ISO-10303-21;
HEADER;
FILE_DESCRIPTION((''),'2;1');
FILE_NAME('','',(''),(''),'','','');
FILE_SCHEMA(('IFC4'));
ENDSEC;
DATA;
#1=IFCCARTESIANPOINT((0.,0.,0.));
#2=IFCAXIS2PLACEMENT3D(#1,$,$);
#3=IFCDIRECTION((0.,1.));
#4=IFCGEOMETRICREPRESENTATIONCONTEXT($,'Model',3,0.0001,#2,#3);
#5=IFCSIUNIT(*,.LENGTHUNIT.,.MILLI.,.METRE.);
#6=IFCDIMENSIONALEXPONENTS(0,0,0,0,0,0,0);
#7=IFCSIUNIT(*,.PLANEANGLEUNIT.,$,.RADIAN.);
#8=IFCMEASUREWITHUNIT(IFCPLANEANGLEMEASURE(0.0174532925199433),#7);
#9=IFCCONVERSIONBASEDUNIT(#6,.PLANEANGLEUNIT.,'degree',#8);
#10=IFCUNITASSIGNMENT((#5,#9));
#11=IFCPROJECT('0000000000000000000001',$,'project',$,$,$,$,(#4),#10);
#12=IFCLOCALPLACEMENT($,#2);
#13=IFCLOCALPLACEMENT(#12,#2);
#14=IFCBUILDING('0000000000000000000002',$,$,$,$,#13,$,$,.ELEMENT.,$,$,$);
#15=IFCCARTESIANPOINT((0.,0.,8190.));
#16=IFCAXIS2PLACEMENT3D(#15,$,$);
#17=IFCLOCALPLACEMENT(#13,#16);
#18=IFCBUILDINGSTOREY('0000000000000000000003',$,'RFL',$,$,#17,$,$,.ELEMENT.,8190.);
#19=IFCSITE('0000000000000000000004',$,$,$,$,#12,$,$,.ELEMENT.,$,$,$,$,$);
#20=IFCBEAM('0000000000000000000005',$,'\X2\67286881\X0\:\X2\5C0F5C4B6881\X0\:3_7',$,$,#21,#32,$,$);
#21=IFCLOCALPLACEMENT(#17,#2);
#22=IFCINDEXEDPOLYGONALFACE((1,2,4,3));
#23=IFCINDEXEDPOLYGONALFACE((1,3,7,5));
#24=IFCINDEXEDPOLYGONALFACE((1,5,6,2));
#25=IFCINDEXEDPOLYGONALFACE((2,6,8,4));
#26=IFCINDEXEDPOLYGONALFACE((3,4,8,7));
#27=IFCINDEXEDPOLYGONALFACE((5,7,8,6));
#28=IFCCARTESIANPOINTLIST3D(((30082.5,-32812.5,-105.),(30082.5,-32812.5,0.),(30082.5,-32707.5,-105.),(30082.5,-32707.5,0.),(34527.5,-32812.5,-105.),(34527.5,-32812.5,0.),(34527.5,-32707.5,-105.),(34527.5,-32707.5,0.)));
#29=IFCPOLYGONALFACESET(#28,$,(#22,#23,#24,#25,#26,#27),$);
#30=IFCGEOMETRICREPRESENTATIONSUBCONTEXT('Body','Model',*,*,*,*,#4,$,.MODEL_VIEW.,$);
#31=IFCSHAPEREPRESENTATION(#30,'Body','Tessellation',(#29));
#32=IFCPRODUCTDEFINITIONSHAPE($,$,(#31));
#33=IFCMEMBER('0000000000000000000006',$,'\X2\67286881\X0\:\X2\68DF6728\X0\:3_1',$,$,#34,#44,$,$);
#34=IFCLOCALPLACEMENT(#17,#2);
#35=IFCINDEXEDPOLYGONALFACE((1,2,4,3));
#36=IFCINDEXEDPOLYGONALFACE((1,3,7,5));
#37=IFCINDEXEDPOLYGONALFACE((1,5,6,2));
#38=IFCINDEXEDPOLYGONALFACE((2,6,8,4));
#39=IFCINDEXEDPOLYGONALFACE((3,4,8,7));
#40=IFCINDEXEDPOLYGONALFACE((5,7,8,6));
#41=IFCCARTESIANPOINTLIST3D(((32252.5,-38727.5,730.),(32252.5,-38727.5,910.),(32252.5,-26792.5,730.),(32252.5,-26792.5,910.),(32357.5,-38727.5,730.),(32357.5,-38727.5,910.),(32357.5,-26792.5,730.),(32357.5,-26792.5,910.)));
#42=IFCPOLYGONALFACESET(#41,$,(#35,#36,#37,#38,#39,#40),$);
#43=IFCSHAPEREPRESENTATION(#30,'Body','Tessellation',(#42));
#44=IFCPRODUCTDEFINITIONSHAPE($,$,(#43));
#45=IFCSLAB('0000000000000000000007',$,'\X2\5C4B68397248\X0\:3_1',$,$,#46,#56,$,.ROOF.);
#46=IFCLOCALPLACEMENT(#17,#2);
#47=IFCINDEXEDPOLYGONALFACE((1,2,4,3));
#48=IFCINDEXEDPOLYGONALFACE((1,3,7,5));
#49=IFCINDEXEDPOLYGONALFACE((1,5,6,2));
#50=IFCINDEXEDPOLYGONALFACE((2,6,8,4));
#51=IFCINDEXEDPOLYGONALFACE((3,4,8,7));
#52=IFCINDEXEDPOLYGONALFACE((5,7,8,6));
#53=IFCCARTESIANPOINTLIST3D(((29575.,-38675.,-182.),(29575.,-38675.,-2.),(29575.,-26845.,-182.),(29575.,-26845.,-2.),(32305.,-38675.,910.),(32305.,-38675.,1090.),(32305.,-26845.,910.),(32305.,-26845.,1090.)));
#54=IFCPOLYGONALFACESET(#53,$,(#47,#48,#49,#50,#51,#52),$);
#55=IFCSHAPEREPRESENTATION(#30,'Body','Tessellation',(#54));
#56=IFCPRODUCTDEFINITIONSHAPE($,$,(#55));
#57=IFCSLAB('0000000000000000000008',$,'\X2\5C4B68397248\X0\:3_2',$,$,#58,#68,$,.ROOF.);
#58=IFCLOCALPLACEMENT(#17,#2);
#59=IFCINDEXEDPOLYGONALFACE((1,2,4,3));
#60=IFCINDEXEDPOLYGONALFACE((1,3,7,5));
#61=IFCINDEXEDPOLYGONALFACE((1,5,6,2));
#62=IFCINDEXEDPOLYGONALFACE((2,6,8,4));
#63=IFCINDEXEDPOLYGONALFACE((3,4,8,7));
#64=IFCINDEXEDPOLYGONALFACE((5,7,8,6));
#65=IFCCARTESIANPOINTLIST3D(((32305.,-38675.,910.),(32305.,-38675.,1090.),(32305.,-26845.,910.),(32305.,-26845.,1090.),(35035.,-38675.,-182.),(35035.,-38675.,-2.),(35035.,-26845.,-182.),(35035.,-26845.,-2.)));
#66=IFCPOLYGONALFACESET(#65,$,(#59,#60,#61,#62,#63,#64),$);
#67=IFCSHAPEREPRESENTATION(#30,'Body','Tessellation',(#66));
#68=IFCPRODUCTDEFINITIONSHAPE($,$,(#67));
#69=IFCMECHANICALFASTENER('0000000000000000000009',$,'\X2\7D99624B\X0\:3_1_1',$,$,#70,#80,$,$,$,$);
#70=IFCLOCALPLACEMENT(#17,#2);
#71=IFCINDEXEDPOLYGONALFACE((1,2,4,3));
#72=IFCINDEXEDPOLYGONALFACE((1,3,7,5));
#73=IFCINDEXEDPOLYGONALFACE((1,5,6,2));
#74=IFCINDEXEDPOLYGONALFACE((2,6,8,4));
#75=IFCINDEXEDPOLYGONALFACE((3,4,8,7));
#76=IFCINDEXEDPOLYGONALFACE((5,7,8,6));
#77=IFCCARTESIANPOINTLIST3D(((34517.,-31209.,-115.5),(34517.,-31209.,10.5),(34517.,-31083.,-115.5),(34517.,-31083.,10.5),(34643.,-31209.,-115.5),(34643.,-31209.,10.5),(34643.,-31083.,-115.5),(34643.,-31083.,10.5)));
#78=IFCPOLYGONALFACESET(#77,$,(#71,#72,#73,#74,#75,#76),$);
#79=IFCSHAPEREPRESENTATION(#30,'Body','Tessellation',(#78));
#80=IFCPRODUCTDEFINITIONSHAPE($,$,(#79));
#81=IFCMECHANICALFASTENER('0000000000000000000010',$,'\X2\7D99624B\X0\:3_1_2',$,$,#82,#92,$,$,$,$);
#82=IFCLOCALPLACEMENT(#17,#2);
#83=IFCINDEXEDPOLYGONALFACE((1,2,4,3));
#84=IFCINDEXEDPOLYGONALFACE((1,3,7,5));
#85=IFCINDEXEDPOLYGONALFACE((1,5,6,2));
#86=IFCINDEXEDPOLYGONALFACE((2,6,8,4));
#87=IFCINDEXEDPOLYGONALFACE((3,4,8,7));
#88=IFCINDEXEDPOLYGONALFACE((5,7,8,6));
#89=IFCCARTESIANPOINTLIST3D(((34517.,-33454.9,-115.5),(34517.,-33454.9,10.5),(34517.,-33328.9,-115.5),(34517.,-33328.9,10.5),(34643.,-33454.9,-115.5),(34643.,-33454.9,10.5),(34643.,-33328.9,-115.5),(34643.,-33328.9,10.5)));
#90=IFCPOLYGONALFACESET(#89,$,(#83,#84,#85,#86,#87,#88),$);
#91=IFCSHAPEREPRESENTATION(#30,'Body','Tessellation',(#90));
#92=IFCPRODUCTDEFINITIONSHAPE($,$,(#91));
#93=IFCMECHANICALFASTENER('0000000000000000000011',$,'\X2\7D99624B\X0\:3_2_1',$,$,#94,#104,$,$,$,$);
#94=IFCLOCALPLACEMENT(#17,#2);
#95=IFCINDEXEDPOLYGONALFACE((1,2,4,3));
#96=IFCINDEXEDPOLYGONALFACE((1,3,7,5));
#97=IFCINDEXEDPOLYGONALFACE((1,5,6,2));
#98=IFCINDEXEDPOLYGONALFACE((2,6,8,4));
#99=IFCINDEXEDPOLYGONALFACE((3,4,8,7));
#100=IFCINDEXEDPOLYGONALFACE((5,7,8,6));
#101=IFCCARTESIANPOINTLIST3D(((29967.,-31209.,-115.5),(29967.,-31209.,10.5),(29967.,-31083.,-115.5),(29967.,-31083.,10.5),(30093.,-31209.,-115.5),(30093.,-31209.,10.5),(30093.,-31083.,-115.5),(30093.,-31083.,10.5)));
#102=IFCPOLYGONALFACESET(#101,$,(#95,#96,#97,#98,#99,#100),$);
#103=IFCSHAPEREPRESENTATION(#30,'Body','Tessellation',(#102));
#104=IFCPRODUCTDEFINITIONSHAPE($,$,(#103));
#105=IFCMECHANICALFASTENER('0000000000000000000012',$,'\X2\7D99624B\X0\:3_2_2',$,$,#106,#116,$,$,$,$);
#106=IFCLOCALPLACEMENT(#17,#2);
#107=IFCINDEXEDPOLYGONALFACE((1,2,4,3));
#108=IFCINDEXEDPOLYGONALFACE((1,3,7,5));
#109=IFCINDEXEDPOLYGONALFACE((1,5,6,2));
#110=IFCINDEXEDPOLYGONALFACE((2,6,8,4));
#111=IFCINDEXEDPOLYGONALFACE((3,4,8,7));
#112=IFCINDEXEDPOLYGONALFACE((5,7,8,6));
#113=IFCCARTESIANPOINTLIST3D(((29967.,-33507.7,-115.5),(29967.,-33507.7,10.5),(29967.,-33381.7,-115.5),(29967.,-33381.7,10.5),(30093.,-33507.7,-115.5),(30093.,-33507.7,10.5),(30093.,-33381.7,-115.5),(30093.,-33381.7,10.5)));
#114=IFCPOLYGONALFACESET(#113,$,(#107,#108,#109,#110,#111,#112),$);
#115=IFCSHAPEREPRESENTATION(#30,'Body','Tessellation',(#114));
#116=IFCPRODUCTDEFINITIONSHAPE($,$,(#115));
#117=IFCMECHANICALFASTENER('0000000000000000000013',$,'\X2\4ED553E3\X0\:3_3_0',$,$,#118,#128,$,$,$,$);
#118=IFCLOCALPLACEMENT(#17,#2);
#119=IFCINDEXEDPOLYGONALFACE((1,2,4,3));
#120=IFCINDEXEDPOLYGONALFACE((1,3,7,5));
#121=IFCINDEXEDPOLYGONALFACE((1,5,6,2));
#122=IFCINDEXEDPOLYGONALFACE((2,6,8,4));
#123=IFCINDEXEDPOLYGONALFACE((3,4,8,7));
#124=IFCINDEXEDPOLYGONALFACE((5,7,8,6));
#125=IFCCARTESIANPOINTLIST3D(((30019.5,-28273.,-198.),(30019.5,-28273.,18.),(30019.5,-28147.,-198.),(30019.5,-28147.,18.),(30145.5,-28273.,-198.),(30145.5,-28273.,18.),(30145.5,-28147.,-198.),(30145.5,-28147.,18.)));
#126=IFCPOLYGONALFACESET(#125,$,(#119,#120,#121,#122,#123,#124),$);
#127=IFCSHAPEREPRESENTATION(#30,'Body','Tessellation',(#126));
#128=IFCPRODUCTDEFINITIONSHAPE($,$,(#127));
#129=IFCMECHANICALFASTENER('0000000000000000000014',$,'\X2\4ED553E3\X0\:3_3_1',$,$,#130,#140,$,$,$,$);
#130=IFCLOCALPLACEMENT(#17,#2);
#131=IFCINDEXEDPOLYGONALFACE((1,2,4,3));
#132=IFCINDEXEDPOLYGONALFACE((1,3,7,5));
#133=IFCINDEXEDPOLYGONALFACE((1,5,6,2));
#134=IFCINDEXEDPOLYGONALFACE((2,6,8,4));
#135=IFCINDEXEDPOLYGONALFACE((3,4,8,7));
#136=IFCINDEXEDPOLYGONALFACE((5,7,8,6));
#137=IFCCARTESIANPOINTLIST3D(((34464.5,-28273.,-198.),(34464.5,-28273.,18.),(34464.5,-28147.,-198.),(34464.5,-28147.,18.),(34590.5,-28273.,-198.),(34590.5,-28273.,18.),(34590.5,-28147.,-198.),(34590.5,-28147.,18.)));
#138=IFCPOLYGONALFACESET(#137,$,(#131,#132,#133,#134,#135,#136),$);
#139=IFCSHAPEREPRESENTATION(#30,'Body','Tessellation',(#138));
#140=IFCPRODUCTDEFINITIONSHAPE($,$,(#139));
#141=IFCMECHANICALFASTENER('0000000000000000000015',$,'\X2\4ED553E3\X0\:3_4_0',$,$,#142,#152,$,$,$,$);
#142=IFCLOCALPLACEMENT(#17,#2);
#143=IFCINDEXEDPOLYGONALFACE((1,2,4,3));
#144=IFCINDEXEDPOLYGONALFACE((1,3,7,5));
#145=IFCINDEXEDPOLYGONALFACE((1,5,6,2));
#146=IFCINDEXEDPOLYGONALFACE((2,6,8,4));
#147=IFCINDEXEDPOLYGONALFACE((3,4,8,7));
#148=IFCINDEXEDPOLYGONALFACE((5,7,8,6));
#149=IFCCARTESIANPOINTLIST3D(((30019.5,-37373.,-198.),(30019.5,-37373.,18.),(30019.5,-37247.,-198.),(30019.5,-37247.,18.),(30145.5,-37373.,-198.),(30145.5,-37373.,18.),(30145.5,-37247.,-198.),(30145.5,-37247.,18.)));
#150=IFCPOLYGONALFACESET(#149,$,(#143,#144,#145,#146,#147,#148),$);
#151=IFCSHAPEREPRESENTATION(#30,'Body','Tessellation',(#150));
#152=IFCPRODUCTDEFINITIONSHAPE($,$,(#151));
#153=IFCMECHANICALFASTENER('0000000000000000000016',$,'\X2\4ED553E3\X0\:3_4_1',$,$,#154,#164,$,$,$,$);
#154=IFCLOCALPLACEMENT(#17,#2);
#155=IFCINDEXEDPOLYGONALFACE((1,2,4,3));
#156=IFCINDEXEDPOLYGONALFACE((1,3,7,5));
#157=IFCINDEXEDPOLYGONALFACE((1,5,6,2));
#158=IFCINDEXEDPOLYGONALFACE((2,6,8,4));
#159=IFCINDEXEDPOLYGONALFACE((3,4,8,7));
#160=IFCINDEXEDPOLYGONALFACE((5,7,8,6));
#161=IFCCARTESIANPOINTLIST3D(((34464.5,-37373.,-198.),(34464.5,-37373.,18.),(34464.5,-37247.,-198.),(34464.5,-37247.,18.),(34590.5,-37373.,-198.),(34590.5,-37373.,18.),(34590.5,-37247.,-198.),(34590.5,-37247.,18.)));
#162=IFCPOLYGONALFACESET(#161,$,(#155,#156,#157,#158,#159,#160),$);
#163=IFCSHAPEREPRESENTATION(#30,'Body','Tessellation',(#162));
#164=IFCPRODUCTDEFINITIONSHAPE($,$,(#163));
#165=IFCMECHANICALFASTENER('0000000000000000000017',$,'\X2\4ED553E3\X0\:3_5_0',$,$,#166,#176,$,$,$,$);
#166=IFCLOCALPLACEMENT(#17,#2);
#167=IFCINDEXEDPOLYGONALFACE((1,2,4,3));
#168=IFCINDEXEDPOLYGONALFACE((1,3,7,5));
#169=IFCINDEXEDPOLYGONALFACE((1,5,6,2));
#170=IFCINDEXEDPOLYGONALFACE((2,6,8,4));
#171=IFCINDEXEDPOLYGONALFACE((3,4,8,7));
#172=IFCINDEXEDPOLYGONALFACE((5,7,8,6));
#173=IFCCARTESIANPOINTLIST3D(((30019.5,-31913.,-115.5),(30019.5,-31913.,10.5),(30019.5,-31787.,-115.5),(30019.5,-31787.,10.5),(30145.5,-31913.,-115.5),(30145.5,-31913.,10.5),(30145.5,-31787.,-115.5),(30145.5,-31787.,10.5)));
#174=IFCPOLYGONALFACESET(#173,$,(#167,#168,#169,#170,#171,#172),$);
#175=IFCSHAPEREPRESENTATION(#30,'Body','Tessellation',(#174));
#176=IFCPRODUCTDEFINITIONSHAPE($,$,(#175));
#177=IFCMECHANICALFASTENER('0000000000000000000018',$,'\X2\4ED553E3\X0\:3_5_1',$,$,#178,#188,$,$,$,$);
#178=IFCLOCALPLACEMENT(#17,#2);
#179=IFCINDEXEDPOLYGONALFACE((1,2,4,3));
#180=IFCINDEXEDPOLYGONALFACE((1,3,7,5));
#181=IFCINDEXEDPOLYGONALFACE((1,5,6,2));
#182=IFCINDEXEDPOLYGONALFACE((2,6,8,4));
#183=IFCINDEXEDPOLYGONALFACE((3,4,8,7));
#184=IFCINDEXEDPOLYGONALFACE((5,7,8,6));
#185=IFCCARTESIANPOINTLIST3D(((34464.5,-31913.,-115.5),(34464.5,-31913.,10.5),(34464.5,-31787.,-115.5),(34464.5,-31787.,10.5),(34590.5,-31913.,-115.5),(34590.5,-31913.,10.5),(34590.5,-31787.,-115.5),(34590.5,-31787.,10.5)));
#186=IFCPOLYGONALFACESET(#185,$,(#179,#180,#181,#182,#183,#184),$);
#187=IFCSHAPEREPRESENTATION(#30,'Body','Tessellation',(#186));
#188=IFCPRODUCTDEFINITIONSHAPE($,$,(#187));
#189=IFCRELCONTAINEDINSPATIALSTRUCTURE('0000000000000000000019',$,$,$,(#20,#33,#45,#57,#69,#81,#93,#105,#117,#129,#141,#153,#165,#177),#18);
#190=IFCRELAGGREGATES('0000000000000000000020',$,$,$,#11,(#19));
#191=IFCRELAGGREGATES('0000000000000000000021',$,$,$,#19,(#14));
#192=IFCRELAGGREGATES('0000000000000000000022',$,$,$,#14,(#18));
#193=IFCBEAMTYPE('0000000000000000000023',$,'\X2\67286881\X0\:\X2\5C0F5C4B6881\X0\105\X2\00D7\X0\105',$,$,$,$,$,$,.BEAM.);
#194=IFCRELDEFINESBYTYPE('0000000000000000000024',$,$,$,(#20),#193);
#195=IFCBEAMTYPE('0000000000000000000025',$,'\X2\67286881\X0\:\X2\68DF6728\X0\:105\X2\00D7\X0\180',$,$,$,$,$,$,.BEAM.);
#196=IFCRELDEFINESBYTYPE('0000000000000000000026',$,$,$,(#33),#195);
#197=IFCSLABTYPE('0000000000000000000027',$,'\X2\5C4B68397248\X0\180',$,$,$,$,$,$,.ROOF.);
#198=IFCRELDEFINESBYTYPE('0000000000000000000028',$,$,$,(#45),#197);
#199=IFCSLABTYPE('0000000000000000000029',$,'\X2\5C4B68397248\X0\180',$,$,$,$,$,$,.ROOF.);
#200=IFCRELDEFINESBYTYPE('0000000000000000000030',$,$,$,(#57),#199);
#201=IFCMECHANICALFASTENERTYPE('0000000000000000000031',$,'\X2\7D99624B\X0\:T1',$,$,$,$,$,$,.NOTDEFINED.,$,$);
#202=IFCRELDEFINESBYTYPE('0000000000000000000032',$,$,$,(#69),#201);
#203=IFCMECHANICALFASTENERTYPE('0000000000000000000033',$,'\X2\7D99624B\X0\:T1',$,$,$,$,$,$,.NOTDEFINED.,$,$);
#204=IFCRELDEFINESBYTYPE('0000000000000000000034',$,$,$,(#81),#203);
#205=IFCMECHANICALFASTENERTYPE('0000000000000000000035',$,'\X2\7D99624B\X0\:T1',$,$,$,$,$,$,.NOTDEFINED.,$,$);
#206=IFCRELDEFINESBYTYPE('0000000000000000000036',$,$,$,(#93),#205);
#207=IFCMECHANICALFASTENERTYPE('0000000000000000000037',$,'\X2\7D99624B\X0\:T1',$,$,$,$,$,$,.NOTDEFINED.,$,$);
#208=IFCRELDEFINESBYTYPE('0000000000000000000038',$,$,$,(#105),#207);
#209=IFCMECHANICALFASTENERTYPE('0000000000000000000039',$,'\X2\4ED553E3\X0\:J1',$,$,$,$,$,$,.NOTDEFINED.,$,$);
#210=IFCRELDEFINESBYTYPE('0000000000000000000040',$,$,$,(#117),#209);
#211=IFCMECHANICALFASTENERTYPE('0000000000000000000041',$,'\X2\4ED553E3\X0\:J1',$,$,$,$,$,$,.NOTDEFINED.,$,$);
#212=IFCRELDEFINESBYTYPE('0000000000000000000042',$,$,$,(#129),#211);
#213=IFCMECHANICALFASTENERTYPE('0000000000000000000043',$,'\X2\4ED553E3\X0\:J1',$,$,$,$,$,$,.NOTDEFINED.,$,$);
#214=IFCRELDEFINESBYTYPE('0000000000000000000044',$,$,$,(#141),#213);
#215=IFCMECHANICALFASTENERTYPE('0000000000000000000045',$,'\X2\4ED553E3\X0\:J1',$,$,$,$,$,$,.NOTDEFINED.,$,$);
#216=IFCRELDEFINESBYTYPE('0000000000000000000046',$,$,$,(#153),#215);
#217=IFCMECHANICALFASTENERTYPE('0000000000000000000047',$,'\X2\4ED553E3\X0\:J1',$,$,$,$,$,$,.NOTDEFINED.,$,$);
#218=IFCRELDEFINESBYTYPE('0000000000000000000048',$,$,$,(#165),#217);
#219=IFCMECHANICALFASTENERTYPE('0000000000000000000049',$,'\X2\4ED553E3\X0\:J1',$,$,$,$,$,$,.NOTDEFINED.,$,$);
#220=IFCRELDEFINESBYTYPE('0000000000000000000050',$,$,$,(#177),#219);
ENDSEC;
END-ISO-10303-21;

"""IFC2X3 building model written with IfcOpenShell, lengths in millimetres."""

from ifc_helpers import new_model, entity, si_unit, converted_unit, direction, frame, origin, origin_with_axes, origin_2d, place, context, subcontext, project, spatial, polyline, rectangle, outline, extrude, type_object, element, save


model = new_model("IFC2X3")

# Units and contexts
model_context = context("Model", 3, precision=0.0001, world=origin(), true_north=direction((0.0, 1.0)))
body_context = subcontext(model_context, "Body", "Model", "MODEL_VIEW")
ifc_project = project(units=[si_unit("LENGTHUNIT", "METRE", prefix="MILLI"), converted_unit("PLANEANGLEUNIT", "degree", entity("IfcPlaneAngleMeasure", 0.0174532925199433), si_unit("PLANEANGLEUNIT", "RADIAN"), dimensions=[0, 0, 0, 0, 0, 0, 0])], contexts=[model_context])

# Site, building, storey
site_placement = place(None, origin())
site = spatial("IfcSite", under=ifc_project, at=site_placement, CompositionType="ELEMENT")
building_placement = place(site_placement, origin())
building = spatial("IfcBuilding", under=site, at=building_placement, CompositionType="ELEMENT")
storey_placement = place(building_placement, frame((0.0, 0.0, 8190.0)))
storey = spatial("IfcBuildingStorey", under=building, at=storey_placement, Name="RFL", CompositionType="ELEMENT", Elevation=8190.0)

# Beam
beam_type_1 = type_object("IfcBeamType", Name="木梁:小屋梁105×105", PredefinedType="BEAM")
beam_1_placement = place(storey_placement, frame((30082.5, -32760.0, -52.5), z_axis=(1.0, 0.0, 0.0), x_axis=(0.0, 1.0, 0.0)))
element("IfcBeam", 1, at=beam_1_placement, inside=storey, type_object=beam_type_1, Name="木梁:小屋梁:3_7", context=body_context, shape_type="SweptSolid", body=[
    extrude(rectangle(XDim=105.0, YDim=105.0, at=origin_2d()), origin_with_axes(), (0.0, 0.0, 1.0), 4445.0),
])

# Member
beam_type_2 = type_object("IfcBeamType", Name="木梁:棟木:105×180", PredefinedType="BEAM")
member_placement = place(storey_placement, frame((32305.0, -26792.5, 820.0), z_axis=(0.0, -1.0, 0.0), x_axis=(-1.0, 0.0, 0.0)))
element("IfcMember", 2, at=member_placement, inside=storey, type_object=beam_type_2, Name="木梁:棟木:3_1", context=body_context, shape_type="SweptSolid", body=[
    extrude(rectangle(XDim=105.0, YDim=180.0, at=origin_2d()), origin_with_axes(), (0.0, 0.0, 1.0), 11935.0),
])

# Slabs
slab_type_1 = type_object("IfcSlabType", Name="屋根版180", PredefinedType="ROOF")
slab_1_placement = place(storey_placement, frame((29575.0, -26845.0, -182.0), z_axis=(0.371391, 0.0, -0.928477), x_axis=(0.928477, 0.0, 0.371391)))
element("IfcSlab", 3, at=slab_1_placement, inside=storey, type_object=slab_type_1, Name="屋根版:3_1", PredefinedType="ROOF", context=body_context, shape_type="SweptSolid", body=[
    extrude(outline(polyline([(0.0, 0.0, 0.0), (2940.3, 0.0, 0.0), (2940.3, 11830.0, 0.0), (0.0, 11830.0, 0.0), (0.0, 0.0, 0.0)])), origin_with_axes(), (0.371391, 0.0, -0.928477), 180.0),
])
slab_type_2 = type_object("IfcSlabType", Name="屋根版180", PredefinedType="ROOF")
slab_2_placement = place(storey_placement, frame((35035.0, -26845.0, -182.0), z_axis=(0.371391, 0.0, 0.928477), x_axis=(-0.928477, 0.0, 0.371391)))
element("IfcSlab", 4, at=slab_2_placement, inside=storey, type_object=slab_type_2, Name="屋根版:3_2", PredefinedType="ROOF", context=body_context, shape_type="SweptSolid", body=[
    extrude(outline(polyline([(0.0, 0.0, 0.0), (2940.3, 0.0, 0.0), (2940.3, 11830.0, 0.0), (0.0, 11830.0, 0.0), (0.0, 0.0, 0.0)])), origin_with_axes(), (0.371391, 0.0, 0.928477), 180.0),
])

# Mechanical fasteners
mechanical_fastener_type_1 = type_object("IfcMechanicalFastenerType", Name="継手:T1")
mechanical_fastener_1_placement = place(storey_placement, frame((34580.0, -31146.0, -115.5)))
element("IfcMechanicalFastener", 5, at=mechanical_fastener_1_placement, inside=storey, type_object=mechanical_fastener_type_1, Name="継手:3_1_1", context=body_context, shape_type="SweptSolid", body=[
    extrude(rectangle(XDim=126.0, YDim=126.0, at=origin_2d()), origin_with_axes(), (0.0, 0.0, 1.0), 126.0),
])
mechanical_fastener_type_2 = type_object("IfcMechanicalFastenerType", Name="継手:T1")
mechanical_fastener_2_placement = place(storey_placement, frame((34580.0, -33391.9, -115.5)))
element("IfcMechanicalFastener", 6, at=mechanical_fastener_2_placement, inside=storey, type_object=mechanical_fastener_type_2, Name="継手:3_1_2", context=body_context, shape_type="SweptSolid", body=[
    extrude(rectangle(XDim=126.0, YDim=126.0, at=origin_2d()), origin_with_axes(), (0.0, 0.0, 1.0), 126.0),
])
mechanical_fastener_type_3 = type_object("IfcMechanicalFastenerType", Name="継手:T1")
mechanical_fastener_3_placement = place(storey_placement, frame((30030.0, -31146.0, -115.5)))
element("IfcMechanicalFastener", 7, at=mechanical_fastener_3_placement, inside=storey, type_object=mechanical_fastener_type_3, Name="継手:3_2_1", context=body_context, shape_type="SweptSolid", body=[
    extrude(rectangle(XDim=126.0, YDim=126.0, at=origin_2d()), origin_with_axes(), (0.0, 0.0, 1.0), 126.0),
])
mechanical_fastener_type_4 = type_object("IfcMechanicalFastenerType", Name="継手:T1")
mechanical_fastener_4_placement = place(storey_placement, frame((30030.0, -33444.7, -115.5)))
element("IfcMechanicalFastener", 8, at=mechanical_fastener_4_placement, inside=storey, type_object=mechanical_fastener_type_4, Name="継手:3_2_2", context=body_context, shape_type="SweptSolid", body=[
    extrude(rectangle(XDim=126.0, YDim=126.0, at=origin_2d()), origin_with_axes(), (0.0, 0.0, 1.0), 126.0),
])
mechanical_fastener_type_5 = type_object("IfcMechanicalFastenerType", Name="仕口:J1")
mechanical_fastener_5_placement = place(storey_placement, frame((30082.5, -28210.0, -198.0)))
element("IfcMechanicalFastener", 9, at=mechanical_fastener_5_placement, inside=storey, type_object=mechanical_fastener_type_5, Name="仕口:3_3_0", context=body_context, shape_type="SweptSolid", body=[
    extrude(rectangle(XDim=126.0, YDim=126.0, at=origin_2d()), origin_with_axes(), (0.0, 0.0, 1.0), 216.0),
])
mechanical_fastener_type_6 = type_object("IfcMechanicalFastenerType", Name="仕口:J1")
mechanical_fastener_6_placement = place(storey_placement, frame((34527.5, -28210.0, -198.0)))
element("IfcMechanicalFastener", 10, at=mechanical_fastener_6_placement, inside=storey, type_object=mechanical_fastener_type_6, Name="仕口:3_3_1", context=body_context, shape_type="SweptSolid", body=[
    extrude(rectangle(XDim=126.0, YDim=126.0, at=origin_2d()), origin_with_axes(), (0.0, 0.0, 1.0), 216.0),
])
mechanical_fastener_type_7 = type_object("IfcMechanicalFastenerType", Name="仕口:J1")
mechanical_fastener_7_placement = place(storey_placement, frame((30082.5, -37310.0, -198.0)))
element("IfcMechanicalFastener", 11, at=mechanical_fastener_7_placement, inside=storey, type_object=mechanical_fastener_type_7, Name="仕口:3_4_0", context=body_context, shape_type="SweptSolid", body=[
    extrude(rectangle(XDim=126.0, YDim=126.0, at=origin_2d()), origin_with_axes(), (0.0, 0.0, 1.0), 216.0),
])
mechanical_fastener_type_8 = type_object("IfcMechanicalFastenerType", Name="仕口:J1")
mechanical_fastener_8_placement = place(storey_placement, frame((34527.5, -37310.0, -198.0)))
element("IfcMechanicalFastener", 12, at=mechanical_fastener_8_placement, inside=storey, type_object=mechanical_fastener_type_8, Name="仕口:3_4_1", context=body_context, shape_type="SweptSolid", body=[
    extrude(rectangle(XDim=126.0, YDim=126.0, at=origin_2d()), origin_with_axes(), (0.0, 0.0, 1.0), 216.0),
])
mechanical_fastener_type_9 = type_object("IfcMechanicalFastenerType", Name="仕口:J1")
mechanical_fastener_9_placement = place(storey_placement, frame((30082.5, -31850.0, -115.5)))
element("IfcMechanicalFastener", 13, at=mechanical_fastener_9_placement, inside=storey, type_object=mechanical_fastener_type_9, Name="仕口:3_5_0", context=body_context, shape_type="SweptSolid", body=[
    extrude(rectangle(XDim=126.0, YDim=126.0, at=origin_2d()), origin_with_axes(), (0.0, 0.0, 1.0), 126.0),
])
mechanical_fastener_type_10 = type_object("IfcMechanicalFastenerType", Name="仕口:J1")
mechanical_fastener_10_placement = place(storey_placement, frame((34527.5, -31850.0, -115.5)))
element("IfcMechanicalFastener", 14, at=mechanical_fastener_10_placement, inside=storey, type_object=mechanical_fastener_type_10, Name="仕口:3_5_1", context=body_context, shape_type="SweptSolid", body=[
    extrude(rectangle(XDim=126.0, YDim=126.0, at=origin_2d()), origin_with_axes(), (0.0, 0.0, 1.0), 126.0),
])

save(model, "model.ifc")
